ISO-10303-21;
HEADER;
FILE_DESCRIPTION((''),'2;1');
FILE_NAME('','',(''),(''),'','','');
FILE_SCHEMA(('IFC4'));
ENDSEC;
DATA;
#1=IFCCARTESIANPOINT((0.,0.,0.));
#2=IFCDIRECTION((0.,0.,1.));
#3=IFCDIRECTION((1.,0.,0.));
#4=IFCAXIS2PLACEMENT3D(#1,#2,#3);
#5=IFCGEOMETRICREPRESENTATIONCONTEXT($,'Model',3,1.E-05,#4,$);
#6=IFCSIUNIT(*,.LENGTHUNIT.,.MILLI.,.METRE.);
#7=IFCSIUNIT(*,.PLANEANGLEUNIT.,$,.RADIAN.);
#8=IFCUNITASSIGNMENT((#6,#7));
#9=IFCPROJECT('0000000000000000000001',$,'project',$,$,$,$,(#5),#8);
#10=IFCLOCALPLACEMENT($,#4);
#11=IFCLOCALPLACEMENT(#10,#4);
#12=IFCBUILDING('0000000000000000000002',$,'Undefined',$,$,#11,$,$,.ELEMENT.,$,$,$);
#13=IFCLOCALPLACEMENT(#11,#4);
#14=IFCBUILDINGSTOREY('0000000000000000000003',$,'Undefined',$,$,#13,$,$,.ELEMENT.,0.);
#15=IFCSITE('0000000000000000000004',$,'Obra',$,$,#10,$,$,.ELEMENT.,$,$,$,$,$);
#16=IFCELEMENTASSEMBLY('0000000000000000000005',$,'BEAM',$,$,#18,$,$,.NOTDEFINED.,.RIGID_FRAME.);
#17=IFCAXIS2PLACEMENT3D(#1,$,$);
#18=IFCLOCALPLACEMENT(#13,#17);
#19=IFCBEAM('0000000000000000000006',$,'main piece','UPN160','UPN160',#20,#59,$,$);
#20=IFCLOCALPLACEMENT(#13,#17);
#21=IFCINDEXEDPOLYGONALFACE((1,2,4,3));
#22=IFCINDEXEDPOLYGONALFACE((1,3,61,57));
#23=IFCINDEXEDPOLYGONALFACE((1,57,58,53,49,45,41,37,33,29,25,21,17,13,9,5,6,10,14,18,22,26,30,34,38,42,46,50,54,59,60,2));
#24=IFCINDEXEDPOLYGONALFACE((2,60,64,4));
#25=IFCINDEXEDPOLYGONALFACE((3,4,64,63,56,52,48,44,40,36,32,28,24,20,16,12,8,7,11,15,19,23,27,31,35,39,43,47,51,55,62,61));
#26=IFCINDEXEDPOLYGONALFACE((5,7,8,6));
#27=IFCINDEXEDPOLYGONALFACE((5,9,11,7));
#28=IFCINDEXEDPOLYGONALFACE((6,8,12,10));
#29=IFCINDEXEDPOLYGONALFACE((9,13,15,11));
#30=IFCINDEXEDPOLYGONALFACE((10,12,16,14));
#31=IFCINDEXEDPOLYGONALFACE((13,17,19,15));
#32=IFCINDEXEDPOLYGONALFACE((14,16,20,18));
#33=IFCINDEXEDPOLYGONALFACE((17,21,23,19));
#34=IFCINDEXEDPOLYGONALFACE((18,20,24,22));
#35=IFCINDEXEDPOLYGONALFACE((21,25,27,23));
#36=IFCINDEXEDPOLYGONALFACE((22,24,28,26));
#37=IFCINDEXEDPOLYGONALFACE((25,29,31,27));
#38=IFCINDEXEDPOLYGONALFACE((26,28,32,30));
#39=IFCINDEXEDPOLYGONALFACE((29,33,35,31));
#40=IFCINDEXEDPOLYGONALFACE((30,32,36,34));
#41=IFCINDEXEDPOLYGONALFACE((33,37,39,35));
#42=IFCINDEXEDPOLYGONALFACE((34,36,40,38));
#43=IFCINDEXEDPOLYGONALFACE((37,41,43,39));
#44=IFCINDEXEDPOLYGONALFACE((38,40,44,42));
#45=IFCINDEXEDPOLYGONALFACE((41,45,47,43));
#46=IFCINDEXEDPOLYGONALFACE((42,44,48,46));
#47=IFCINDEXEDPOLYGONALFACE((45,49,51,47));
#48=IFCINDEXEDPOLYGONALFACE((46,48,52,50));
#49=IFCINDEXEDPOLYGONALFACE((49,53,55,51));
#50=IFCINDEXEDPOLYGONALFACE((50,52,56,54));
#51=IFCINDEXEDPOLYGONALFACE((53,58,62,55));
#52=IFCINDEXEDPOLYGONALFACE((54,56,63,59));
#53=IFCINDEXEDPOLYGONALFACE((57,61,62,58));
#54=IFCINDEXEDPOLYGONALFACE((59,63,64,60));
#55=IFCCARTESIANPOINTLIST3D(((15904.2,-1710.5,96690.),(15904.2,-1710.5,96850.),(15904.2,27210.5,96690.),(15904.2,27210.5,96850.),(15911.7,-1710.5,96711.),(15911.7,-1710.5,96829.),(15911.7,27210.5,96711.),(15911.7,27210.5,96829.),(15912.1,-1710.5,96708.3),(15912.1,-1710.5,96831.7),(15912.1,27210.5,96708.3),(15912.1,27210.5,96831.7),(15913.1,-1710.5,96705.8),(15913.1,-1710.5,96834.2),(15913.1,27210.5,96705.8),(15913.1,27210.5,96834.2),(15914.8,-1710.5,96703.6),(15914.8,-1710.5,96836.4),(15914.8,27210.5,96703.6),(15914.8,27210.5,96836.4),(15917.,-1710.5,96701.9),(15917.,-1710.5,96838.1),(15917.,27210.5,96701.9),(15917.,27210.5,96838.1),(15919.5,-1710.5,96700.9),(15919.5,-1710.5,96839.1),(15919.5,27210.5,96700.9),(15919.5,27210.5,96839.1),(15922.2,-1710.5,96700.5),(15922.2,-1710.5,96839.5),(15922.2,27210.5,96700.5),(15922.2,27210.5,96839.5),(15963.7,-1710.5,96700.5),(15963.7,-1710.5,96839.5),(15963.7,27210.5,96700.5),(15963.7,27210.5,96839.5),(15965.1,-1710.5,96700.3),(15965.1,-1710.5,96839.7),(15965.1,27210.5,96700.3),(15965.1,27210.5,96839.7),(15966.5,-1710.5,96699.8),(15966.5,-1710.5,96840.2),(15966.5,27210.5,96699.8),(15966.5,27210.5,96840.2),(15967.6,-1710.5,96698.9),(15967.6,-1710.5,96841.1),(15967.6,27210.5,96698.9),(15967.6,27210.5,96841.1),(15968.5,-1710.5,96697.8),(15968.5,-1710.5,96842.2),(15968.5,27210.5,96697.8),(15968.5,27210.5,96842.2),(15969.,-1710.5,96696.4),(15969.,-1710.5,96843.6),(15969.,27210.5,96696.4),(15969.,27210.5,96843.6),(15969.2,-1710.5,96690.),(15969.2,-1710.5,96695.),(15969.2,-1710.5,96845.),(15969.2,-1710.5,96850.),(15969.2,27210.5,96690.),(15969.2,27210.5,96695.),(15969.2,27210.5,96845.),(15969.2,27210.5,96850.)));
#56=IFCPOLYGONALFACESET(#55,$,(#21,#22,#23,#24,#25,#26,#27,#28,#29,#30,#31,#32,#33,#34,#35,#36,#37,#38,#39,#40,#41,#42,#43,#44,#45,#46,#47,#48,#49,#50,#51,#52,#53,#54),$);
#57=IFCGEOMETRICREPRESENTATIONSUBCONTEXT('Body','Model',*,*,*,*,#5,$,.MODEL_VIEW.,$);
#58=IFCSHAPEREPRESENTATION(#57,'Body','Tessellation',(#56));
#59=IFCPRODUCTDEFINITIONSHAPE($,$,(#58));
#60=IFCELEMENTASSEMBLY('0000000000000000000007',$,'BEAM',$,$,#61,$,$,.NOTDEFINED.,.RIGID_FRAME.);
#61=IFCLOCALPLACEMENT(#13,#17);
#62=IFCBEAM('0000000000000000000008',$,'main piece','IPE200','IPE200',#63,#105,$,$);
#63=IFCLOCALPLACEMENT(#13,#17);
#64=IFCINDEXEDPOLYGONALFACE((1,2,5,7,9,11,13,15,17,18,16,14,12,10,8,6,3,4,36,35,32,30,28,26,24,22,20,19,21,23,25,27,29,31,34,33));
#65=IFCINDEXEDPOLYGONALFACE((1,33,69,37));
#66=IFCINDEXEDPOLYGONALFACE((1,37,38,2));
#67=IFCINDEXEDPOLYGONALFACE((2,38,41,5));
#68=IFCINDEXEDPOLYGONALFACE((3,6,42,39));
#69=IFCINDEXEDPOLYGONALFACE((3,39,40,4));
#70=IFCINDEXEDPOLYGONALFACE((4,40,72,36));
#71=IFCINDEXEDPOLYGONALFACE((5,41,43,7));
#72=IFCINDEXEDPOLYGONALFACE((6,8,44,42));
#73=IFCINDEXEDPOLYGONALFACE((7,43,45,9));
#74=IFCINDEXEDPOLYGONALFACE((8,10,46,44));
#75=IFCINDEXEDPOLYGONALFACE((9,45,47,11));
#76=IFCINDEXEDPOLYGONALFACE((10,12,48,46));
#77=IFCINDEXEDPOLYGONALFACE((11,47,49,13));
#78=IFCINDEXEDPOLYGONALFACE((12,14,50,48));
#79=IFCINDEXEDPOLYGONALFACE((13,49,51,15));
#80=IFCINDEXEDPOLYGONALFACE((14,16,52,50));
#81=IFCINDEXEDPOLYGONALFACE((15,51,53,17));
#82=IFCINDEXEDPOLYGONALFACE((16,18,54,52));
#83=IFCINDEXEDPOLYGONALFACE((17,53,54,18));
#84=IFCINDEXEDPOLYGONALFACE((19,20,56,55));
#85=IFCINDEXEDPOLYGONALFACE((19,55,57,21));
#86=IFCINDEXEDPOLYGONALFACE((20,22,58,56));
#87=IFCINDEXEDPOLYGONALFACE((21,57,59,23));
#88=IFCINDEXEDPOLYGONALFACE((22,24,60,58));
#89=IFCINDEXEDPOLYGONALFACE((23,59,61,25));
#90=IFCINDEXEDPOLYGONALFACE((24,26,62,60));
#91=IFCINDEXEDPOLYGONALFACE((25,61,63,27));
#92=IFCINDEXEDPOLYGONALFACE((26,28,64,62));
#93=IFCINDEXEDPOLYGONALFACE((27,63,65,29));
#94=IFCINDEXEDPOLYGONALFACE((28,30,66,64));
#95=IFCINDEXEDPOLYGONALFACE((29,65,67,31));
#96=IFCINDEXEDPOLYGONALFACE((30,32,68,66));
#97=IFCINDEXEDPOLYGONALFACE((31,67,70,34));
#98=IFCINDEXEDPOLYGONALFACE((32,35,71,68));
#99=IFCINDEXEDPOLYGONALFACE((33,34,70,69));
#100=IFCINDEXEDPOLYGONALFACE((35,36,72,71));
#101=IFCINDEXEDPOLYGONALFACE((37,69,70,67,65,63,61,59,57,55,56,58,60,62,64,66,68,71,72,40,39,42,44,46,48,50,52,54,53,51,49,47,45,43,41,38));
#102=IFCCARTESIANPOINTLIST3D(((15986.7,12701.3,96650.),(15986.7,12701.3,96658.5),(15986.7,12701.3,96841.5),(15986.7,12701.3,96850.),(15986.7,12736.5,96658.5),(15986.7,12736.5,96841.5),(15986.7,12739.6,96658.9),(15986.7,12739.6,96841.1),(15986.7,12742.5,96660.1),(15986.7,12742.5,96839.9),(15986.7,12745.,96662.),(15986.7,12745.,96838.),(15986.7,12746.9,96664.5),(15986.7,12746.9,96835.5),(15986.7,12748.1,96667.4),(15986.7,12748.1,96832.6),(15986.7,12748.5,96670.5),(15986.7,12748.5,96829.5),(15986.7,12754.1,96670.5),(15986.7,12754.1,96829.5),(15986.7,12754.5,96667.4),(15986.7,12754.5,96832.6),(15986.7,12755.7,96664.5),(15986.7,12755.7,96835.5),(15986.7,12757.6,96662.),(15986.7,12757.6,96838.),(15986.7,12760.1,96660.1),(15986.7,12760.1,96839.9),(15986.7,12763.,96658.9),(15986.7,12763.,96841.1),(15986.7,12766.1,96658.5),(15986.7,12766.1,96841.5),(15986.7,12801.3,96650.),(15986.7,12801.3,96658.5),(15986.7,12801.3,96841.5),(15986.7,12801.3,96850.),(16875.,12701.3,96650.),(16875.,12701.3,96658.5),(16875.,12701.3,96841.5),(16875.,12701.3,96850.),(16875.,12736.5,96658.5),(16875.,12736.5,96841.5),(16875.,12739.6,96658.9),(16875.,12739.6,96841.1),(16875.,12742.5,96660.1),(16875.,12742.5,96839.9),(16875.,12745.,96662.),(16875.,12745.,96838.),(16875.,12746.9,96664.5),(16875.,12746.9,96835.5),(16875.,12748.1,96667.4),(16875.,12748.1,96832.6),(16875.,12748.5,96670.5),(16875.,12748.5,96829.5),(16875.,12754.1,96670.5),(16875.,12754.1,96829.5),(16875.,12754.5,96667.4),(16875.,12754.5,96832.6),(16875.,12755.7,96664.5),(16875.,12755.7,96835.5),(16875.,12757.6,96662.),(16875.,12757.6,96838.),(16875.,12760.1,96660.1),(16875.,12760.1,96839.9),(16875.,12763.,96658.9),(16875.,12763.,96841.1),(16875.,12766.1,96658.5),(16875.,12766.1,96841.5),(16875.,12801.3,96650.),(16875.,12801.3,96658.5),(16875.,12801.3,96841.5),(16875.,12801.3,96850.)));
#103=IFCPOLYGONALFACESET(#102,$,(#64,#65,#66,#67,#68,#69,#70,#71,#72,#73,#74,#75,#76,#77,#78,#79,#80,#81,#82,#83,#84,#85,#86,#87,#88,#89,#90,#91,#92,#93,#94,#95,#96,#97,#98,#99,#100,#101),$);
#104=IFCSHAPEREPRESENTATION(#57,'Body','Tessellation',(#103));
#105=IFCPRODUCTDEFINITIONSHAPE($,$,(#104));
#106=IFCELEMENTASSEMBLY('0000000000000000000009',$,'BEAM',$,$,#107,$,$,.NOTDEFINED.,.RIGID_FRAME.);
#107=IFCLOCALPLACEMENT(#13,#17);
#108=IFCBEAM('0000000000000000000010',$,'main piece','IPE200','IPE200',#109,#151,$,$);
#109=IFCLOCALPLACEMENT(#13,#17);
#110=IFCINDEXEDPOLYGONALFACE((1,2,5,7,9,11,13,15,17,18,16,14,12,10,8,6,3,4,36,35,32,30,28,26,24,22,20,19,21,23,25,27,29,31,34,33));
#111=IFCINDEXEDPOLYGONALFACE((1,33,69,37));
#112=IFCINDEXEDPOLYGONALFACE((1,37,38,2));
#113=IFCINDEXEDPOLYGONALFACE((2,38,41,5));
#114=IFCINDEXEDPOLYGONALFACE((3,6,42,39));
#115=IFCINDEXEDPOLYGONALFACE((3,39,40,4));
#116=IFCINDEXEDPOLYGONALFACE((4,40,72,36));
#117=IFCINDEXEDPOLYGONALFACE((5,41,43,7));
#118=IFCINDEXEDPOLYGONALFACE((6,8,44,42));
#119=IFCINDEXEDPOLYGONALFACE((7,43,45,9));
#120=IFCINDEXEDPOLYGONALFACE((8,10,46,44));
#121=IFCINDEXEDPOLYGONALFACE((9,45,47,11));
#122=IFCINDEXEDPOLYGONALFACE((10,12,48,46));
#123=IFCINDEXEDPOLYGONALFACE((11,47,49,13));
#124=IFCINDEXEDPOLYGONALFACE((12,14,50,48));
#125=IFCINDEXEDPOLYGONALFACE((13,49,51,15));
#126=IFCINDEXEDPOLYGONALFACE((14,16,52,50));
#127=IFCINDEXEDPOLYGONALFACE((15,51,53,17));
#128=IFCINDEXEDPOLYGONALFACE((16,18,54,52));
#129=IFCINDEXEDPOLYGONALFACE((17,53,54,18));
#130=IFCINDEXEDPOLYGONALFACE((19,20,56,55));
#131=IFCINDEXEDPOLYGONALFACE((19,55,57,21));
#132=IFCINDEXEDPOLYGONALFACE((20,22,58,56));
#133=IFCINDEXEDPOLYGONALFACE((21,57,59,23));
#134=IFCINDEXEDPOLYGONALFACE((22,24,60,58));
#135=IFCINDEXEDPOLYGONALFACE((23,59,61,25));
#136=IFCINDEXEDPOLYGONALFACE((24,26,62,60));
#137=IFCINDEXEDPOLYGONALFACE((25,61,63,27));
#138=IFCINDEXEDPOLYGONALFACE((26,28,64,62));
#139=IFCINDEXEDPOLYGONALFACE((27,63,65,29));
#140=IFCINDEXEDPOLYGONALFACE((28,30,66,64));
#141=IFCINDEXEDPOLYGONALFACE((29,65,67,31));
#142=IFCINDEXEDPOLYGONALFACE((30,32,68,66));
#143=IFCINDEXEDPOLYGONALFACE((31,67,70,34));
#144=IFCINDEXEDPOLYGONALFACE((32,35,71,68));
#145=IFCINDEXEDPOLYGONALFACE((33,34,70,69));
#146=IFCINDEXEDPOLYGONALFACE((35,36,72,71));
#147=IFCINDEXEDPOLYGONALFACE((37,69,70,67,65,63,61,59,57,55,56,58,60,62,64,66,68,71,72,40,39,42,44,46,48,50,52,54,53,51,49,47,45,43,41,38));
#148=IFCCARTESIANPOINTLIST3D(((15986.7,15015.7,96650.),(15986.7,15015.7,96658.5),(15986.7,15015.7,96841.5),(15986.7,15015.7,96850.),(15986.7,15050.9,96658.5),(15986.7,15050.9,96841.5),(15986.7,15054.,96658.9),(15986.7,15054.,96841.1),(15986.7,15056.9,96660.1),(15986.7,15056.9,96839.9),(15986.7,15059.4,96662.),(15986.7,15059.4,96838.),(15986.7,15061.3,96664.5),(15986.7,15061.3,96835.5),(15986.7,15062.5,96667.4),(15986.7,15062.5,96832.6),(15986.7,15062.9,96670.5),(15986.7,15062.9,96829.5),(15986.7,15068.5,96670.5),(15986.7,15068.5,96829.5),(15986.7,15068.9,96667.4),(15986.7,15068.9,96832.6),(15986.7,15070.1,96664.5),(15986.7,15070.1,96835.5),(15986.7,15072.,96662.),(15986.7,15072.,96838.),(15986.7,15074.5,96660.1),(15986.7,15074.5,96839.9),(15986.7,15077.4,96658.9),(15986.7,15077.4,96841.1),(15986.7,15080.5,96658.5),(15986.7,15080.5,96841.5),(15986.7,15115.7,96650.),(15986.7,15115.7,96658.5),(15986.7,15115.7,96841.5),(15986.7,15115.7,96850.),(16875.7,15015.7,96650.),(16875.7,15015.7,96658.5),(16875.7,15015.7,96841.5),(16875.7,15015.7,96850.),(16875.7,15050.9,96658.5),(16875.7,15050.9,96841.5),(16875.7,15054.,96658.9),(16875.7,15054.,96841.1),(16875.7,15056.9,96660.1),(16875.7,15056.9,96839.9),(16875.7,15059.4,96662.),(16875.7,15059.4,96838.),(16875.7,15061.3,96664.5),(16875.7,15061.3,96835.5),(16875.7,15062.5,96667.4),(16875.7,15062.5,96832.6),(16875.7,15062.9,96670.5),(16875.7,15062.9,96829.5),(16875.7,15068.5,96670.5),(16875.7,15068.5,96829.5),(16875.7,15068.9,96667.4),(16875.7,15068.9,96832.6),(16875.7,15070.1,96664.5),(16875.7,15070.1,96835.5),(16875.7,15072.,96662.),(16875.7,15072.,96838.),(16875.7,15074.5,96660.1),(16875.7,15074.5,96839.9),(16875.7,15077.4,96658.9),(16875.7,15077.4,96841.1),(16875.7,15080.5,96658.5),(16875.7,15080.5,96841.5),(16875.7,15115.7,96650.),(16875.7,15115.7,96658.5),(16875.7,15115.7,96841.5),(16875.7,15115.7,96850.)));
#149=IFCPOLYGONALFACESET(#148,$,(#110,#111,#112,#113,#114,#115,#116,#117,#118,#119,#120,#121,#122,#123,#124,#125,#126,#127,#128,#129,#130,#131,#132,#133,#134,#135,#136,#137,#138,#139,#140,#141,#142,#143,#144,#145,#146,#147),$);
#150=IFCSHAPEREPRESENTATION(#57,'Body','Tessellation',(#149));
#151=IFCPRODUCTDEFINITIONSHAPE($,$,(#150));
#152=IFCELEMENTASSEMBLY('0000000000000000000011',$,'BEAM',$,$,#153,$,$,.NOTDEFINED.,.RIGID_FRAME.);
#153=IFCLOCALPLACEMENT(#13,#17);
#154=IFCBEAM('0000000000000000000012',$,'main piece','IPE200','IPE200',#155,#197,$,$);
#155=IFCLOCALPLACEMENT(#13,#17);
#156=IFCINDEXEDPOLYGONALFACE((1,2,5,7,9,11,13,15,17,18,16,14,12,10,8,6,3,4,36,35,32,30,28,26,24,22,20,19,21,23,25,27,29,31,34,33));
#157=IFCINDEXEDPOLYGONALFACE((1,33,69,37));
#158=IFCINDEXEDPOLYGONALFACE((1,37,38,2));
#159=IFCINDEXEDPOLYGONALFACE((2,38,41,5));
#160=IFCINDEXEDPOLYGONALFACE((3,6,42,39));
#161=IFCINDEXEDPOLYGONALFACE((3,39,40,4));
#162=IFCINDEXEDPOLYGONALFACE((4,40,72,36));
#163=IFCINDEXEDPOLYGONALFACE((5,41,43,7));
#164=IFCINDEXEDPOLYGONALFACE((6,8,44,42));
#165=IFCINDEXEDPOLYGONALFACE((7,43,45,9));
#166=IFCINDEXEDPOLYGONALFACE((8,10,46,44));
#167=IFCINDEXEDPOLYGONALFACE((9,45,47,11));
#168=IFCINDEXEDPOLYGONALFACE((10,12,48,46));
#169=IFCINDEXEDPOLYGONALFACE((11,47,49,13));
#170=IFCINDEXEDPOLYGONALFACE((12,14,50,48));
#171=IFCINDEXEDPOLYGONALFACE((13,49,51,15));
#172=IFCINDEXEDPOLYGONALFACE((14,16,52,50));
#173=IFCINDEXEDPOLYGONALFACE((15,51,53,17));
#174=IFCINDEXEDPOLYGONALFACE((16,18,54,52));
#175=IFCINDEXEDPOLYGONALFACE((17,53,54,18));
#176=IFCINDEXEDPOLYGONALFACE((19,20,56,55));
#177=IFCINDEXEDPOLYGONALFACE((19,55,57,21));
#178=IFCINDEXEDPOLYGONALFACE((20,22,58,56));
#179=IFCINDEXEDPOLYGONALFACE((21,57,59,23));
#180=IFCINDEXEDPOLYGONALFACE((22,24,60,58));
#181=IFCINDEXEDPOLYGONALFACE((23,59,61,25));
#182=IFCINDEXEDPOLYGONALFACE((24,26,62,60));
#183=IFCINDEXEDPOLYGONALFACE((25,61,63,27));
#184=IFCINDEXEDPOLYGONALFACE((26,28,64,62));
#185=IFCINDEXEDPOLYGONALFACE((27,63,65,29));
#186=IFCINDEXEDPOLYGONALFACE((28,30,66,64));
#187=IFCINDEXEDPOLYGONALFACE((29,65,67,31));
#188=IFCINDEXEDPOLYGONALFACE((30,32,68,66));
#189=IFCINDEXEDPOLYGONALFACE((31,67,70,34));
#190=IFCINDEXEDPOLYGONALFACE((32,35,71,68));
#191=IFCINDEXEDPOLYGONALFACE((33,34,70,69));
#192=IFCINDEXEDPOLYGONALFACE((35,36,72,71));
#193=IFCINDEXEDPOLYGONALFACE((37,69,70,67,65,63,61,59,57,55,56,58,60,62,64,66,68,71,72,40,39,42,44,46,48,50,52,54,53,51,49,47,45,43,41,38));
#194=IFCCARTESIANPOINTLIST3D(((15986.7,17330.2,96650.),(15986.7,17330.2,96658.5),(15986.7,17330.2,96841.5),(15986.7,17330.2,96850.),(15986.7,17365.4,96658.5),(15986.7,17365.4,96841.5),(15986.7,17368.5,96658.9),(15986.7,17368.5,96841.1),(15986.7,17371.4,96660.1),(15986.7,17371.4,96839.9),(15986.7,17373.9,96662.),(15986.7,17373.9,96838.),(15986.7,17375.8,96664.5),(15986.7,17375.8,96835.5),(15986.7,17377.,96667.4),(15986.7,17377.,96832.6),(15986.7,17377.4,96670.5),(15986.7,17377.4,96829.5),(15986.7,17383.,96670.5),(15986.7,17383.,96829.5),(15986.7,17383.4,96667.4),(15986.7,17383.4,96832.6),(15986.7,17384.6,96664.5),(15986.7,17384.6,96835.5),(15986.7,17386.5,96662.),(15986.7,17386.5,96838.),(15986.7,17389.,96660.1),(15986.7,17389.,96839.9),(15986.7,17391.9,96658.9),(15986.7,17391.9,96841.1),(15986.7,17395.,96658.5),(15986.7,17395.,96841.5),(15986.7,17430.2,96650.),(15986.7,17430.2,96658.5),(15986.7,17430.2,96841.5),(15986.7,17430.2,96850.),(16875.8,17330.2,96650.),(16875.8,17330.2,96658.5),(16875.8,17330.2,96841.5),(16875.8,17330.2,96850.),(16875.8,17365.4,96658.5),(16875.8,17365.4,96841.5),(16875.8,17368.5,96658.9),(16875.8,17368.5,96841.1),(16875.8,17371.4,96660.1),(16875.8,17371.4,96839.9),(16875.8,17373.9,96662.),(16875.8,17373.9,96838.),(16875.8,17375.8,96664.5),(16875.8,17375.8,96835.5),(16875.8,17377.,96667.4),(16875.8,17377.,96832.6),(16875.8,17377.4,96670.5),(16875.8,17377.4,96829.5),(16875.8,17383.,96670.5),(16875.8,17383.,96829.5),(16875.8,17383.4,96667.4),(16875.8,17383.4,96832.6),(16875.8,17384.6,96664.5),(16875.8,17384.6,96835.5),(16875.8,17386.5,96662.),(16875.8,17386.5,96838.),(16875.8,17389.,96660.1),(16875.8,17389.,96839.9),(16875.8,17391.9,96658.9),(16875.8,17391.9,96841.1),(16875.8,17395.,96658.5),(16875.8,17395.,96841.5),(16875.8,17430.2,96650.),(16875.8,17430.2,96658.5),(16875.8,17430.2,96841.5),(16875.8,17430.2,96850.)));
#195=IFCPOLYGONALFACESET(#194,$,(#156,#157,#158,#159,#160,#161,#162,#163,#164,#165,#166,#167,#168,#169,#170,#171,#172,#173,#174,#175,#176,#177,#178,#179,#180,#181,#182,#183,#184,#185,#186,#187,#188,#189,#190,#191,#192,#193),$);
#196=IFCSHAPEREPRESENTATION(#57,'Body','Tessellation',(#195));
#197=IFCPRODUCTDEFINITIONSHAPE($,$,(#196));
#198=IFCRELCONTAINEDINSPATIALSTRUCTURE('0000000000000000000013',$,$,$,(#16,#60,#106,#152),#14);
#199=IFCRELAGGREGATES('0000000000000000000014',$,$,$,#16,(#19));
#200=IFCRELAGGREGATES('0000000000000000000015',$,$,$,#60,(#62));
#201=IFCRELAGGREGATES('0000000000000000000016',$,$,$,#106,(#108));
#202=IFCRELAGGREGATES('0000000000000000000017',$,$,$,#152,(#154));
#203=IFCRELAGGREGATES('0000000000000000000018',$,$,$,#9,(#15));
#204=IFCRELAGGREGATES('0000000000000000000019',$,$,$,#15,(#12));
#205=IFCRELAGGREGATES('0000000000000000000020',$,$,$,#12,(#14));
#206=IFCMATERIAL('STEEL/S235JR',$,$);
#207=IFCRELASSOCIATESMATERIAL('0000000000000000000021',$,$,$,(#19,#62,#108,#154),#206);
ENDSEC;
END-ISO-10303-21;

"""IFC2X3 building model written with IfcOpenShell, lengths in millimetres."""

from ifc_helpers import new_model, si_unit, frame, origin_with_axes, origin_2d_with_axis, place, context, subcontext, project, spatial, i_section, u_section, extrude, material, element, aggregate, save


model = new_model("IFC2X3")

# Units and contexts
model_context = context("Model", 3, precision=1e-05, world=origin_with_axes())
body_context = subcontext(model_context, "Body", "Model", "MODEL_VIEW")
ifc_project = project(units=[si_unit("LENGTHUNIT", "METRE", prefix="MILLI"), si_unit("PLANEANGLEUNIT", "RADIAN")], contexts=[model_context])

# Site, building, storey
site_placement = place(None, origin_with_axes())
site = spatial("IfcSite", under=ifc_project, at=site_placement, Name="Obra", CompositionType="ELEMENT")
building_placement = place(site_placement, origin_with_axes())
building = spatial("IfcBuilding", under=site, at=building_placement, Name="Undefined", CompositionType="ELEMENT")
storey_placement = place(building_placement, origin_with_axes())
storey = spatial("IfcBuildingStorey", under=building, at=storey_placement, Name="Undefined", CompositionType="ELEMENT", Elevation=0.0)

# Element assemblies, beams
assembly_1_placement = place(storey_placement, origin_with_axes())
assembly_1 = element("IfcElementAssembly", 1, at=assembly_1_placement, inside=storey, Name="BEAM", AssemblyPlace="NOTDEFINED", PredefinedType="RIGID_FRAME")
ifc_material = material(Name="STEEL/S235JR")
beam_1_placement = place(assembly_1_placement, frame((15936.7, 27210.5, 96770.0), z_axis=(0.0, 0.0, -1.0), x_axis=(0.0, -1.0, 0.0)))
beam_1 = element("IfcBeam", 2, at=beam_1_placement, material=ifc_material, Name="main piece", Description="UPN160", ObjectType="UPN160", context=body_context, shape_type="SweptSolid", body=[
    extrude(u_section(Depth=160.0, FlangeWidth=65.0, WebThickness=7.5, FlangeThickness=10.5, FilletRadius=10.5, EdgeRadius=5.5, at=origin_2d_with_axis()), frame((28921.0, 0.0, 0.0), z_axis=(-1.0, 0.0, 0.0), x_axis=(0.0, -1.0, 0.0)), (0.0, 0.0, 1.0), 28921.0),
])
aggregate(assembly_1, [beam_1])
assembly_2_placement = place(storey_placement, origin_with_axes())
assembly_2 = element("IfcElementAssembly", 3, at=assembly_2_placement, inside=storey, Name="BEAM", AssemblyPlace="NOTDEFINED", PredefinedType="RIGID_FRAME")
beam_2_placement = place(assembly_2_placement, frame((16875.0, 12751.3, 96750.0), z_axis=(0.0, 0.0, 1.0), x_axis=(-1.0, 0.0, 0.0)))
beam_2 = element("IfcBeam", 4, at=beam_2_placement, material=ifc_material, Name="main piece", Description="IPE200", ObjectType="IPE200", context=body_context, shape_type="SweptSolid", body=[
    extrude(i_section(OverallWidth=100.0, OverallDepth=200.0, WebThickness=5.6, FlangeThickness=8.5, FilletRadius=12.0, at=origin_2d_with_axis()), frame((888.3, 0.0, 0.0), z_axis=(-1.0, 0.0, 0.0), x_axis=(0.0, -1.0, 0.0)), (0.0, 0.0, 1.0), 888.3),
])
aggregate(assembly_2, [beam_2])
assembly_3_placement = place(storey_placement, origin_with_axes())
assembly_3 = element("IfcElementAssembly", 5, at=assembly_3_placement, inside=storey, Name="BEAM", AssemblyPlace="NOTDEFINED", PredefinedType="RIGID_FRAME")
beam_3_placement = place(assembly_3_placement, frame((15986.7, 15065.7, 96750.0), z_axis=(0.0, 0.0, 1.0), x_axis=(1.0, 0.0, 0.0)))
beam_3 = element("IfcBeam", 6, at=beam_3_placement, material=ifc_material, Name="main piece", Description="IPE200", ObjectType="IPE200", context=body_context, shape_type="SweptSolid", body=[
    extrude(i_section(OverallWidth=100.0, OverallDepth=200.0, WebThickness=5.6, FlangeThickness=8.5, FilletRadius=12.0, at=origin_2d_with_axis()), frame((889.0, 0.0, 0.0), z_axis=(-1.0, 0.0, 0.0), x_axis=(0.0, -1.0, 0.0)), (0.0, 0.0, 1.0), 889.0),
])
aggregate(assembly_3, [beam_3])
assembly_4_placement = place(storey_placement, origin_with_axes())
assembly_4 = element("IfcElementAssembly", 7, at=assembly_4_placement, inside=storey, Name="BEAM", AssemblyPlace="NOTDEFINED", PredefinedType="RIGID_FRAME")
beam_4_placement = place(assembly_4_placement, frame((16875.8, 17380.2, 96750.0), z_axis=(0.0, 0.0, 1.0), x_axis=(-1.0, 0.0, 0.0)))
beam_4 = element("IfcBeam", 8, at=beam_4_placement, material=ifc_material, Name="main piece", Description="IPE200", ObjectType="IPE200", context=body_context, shape_type="SweptSolid", body=[
    extrude(i_section(OverallWidth=100.0, OverallDepth=200.0, WebThickness=5.6, FlangeThickness=8.5, FilletRadius=12.0, at=origin_2d_with_axis()), frame((889.1, 0.0, 0.0), z_axis=(-1.0, 0.0, 0.0), x_axis=(0.0, -1.0, 0.0)), (0.0, 0.0, 1.0), 889.1),
])
aggregate(assembly_4, [beam_4])

save(model, "model.ifc")
